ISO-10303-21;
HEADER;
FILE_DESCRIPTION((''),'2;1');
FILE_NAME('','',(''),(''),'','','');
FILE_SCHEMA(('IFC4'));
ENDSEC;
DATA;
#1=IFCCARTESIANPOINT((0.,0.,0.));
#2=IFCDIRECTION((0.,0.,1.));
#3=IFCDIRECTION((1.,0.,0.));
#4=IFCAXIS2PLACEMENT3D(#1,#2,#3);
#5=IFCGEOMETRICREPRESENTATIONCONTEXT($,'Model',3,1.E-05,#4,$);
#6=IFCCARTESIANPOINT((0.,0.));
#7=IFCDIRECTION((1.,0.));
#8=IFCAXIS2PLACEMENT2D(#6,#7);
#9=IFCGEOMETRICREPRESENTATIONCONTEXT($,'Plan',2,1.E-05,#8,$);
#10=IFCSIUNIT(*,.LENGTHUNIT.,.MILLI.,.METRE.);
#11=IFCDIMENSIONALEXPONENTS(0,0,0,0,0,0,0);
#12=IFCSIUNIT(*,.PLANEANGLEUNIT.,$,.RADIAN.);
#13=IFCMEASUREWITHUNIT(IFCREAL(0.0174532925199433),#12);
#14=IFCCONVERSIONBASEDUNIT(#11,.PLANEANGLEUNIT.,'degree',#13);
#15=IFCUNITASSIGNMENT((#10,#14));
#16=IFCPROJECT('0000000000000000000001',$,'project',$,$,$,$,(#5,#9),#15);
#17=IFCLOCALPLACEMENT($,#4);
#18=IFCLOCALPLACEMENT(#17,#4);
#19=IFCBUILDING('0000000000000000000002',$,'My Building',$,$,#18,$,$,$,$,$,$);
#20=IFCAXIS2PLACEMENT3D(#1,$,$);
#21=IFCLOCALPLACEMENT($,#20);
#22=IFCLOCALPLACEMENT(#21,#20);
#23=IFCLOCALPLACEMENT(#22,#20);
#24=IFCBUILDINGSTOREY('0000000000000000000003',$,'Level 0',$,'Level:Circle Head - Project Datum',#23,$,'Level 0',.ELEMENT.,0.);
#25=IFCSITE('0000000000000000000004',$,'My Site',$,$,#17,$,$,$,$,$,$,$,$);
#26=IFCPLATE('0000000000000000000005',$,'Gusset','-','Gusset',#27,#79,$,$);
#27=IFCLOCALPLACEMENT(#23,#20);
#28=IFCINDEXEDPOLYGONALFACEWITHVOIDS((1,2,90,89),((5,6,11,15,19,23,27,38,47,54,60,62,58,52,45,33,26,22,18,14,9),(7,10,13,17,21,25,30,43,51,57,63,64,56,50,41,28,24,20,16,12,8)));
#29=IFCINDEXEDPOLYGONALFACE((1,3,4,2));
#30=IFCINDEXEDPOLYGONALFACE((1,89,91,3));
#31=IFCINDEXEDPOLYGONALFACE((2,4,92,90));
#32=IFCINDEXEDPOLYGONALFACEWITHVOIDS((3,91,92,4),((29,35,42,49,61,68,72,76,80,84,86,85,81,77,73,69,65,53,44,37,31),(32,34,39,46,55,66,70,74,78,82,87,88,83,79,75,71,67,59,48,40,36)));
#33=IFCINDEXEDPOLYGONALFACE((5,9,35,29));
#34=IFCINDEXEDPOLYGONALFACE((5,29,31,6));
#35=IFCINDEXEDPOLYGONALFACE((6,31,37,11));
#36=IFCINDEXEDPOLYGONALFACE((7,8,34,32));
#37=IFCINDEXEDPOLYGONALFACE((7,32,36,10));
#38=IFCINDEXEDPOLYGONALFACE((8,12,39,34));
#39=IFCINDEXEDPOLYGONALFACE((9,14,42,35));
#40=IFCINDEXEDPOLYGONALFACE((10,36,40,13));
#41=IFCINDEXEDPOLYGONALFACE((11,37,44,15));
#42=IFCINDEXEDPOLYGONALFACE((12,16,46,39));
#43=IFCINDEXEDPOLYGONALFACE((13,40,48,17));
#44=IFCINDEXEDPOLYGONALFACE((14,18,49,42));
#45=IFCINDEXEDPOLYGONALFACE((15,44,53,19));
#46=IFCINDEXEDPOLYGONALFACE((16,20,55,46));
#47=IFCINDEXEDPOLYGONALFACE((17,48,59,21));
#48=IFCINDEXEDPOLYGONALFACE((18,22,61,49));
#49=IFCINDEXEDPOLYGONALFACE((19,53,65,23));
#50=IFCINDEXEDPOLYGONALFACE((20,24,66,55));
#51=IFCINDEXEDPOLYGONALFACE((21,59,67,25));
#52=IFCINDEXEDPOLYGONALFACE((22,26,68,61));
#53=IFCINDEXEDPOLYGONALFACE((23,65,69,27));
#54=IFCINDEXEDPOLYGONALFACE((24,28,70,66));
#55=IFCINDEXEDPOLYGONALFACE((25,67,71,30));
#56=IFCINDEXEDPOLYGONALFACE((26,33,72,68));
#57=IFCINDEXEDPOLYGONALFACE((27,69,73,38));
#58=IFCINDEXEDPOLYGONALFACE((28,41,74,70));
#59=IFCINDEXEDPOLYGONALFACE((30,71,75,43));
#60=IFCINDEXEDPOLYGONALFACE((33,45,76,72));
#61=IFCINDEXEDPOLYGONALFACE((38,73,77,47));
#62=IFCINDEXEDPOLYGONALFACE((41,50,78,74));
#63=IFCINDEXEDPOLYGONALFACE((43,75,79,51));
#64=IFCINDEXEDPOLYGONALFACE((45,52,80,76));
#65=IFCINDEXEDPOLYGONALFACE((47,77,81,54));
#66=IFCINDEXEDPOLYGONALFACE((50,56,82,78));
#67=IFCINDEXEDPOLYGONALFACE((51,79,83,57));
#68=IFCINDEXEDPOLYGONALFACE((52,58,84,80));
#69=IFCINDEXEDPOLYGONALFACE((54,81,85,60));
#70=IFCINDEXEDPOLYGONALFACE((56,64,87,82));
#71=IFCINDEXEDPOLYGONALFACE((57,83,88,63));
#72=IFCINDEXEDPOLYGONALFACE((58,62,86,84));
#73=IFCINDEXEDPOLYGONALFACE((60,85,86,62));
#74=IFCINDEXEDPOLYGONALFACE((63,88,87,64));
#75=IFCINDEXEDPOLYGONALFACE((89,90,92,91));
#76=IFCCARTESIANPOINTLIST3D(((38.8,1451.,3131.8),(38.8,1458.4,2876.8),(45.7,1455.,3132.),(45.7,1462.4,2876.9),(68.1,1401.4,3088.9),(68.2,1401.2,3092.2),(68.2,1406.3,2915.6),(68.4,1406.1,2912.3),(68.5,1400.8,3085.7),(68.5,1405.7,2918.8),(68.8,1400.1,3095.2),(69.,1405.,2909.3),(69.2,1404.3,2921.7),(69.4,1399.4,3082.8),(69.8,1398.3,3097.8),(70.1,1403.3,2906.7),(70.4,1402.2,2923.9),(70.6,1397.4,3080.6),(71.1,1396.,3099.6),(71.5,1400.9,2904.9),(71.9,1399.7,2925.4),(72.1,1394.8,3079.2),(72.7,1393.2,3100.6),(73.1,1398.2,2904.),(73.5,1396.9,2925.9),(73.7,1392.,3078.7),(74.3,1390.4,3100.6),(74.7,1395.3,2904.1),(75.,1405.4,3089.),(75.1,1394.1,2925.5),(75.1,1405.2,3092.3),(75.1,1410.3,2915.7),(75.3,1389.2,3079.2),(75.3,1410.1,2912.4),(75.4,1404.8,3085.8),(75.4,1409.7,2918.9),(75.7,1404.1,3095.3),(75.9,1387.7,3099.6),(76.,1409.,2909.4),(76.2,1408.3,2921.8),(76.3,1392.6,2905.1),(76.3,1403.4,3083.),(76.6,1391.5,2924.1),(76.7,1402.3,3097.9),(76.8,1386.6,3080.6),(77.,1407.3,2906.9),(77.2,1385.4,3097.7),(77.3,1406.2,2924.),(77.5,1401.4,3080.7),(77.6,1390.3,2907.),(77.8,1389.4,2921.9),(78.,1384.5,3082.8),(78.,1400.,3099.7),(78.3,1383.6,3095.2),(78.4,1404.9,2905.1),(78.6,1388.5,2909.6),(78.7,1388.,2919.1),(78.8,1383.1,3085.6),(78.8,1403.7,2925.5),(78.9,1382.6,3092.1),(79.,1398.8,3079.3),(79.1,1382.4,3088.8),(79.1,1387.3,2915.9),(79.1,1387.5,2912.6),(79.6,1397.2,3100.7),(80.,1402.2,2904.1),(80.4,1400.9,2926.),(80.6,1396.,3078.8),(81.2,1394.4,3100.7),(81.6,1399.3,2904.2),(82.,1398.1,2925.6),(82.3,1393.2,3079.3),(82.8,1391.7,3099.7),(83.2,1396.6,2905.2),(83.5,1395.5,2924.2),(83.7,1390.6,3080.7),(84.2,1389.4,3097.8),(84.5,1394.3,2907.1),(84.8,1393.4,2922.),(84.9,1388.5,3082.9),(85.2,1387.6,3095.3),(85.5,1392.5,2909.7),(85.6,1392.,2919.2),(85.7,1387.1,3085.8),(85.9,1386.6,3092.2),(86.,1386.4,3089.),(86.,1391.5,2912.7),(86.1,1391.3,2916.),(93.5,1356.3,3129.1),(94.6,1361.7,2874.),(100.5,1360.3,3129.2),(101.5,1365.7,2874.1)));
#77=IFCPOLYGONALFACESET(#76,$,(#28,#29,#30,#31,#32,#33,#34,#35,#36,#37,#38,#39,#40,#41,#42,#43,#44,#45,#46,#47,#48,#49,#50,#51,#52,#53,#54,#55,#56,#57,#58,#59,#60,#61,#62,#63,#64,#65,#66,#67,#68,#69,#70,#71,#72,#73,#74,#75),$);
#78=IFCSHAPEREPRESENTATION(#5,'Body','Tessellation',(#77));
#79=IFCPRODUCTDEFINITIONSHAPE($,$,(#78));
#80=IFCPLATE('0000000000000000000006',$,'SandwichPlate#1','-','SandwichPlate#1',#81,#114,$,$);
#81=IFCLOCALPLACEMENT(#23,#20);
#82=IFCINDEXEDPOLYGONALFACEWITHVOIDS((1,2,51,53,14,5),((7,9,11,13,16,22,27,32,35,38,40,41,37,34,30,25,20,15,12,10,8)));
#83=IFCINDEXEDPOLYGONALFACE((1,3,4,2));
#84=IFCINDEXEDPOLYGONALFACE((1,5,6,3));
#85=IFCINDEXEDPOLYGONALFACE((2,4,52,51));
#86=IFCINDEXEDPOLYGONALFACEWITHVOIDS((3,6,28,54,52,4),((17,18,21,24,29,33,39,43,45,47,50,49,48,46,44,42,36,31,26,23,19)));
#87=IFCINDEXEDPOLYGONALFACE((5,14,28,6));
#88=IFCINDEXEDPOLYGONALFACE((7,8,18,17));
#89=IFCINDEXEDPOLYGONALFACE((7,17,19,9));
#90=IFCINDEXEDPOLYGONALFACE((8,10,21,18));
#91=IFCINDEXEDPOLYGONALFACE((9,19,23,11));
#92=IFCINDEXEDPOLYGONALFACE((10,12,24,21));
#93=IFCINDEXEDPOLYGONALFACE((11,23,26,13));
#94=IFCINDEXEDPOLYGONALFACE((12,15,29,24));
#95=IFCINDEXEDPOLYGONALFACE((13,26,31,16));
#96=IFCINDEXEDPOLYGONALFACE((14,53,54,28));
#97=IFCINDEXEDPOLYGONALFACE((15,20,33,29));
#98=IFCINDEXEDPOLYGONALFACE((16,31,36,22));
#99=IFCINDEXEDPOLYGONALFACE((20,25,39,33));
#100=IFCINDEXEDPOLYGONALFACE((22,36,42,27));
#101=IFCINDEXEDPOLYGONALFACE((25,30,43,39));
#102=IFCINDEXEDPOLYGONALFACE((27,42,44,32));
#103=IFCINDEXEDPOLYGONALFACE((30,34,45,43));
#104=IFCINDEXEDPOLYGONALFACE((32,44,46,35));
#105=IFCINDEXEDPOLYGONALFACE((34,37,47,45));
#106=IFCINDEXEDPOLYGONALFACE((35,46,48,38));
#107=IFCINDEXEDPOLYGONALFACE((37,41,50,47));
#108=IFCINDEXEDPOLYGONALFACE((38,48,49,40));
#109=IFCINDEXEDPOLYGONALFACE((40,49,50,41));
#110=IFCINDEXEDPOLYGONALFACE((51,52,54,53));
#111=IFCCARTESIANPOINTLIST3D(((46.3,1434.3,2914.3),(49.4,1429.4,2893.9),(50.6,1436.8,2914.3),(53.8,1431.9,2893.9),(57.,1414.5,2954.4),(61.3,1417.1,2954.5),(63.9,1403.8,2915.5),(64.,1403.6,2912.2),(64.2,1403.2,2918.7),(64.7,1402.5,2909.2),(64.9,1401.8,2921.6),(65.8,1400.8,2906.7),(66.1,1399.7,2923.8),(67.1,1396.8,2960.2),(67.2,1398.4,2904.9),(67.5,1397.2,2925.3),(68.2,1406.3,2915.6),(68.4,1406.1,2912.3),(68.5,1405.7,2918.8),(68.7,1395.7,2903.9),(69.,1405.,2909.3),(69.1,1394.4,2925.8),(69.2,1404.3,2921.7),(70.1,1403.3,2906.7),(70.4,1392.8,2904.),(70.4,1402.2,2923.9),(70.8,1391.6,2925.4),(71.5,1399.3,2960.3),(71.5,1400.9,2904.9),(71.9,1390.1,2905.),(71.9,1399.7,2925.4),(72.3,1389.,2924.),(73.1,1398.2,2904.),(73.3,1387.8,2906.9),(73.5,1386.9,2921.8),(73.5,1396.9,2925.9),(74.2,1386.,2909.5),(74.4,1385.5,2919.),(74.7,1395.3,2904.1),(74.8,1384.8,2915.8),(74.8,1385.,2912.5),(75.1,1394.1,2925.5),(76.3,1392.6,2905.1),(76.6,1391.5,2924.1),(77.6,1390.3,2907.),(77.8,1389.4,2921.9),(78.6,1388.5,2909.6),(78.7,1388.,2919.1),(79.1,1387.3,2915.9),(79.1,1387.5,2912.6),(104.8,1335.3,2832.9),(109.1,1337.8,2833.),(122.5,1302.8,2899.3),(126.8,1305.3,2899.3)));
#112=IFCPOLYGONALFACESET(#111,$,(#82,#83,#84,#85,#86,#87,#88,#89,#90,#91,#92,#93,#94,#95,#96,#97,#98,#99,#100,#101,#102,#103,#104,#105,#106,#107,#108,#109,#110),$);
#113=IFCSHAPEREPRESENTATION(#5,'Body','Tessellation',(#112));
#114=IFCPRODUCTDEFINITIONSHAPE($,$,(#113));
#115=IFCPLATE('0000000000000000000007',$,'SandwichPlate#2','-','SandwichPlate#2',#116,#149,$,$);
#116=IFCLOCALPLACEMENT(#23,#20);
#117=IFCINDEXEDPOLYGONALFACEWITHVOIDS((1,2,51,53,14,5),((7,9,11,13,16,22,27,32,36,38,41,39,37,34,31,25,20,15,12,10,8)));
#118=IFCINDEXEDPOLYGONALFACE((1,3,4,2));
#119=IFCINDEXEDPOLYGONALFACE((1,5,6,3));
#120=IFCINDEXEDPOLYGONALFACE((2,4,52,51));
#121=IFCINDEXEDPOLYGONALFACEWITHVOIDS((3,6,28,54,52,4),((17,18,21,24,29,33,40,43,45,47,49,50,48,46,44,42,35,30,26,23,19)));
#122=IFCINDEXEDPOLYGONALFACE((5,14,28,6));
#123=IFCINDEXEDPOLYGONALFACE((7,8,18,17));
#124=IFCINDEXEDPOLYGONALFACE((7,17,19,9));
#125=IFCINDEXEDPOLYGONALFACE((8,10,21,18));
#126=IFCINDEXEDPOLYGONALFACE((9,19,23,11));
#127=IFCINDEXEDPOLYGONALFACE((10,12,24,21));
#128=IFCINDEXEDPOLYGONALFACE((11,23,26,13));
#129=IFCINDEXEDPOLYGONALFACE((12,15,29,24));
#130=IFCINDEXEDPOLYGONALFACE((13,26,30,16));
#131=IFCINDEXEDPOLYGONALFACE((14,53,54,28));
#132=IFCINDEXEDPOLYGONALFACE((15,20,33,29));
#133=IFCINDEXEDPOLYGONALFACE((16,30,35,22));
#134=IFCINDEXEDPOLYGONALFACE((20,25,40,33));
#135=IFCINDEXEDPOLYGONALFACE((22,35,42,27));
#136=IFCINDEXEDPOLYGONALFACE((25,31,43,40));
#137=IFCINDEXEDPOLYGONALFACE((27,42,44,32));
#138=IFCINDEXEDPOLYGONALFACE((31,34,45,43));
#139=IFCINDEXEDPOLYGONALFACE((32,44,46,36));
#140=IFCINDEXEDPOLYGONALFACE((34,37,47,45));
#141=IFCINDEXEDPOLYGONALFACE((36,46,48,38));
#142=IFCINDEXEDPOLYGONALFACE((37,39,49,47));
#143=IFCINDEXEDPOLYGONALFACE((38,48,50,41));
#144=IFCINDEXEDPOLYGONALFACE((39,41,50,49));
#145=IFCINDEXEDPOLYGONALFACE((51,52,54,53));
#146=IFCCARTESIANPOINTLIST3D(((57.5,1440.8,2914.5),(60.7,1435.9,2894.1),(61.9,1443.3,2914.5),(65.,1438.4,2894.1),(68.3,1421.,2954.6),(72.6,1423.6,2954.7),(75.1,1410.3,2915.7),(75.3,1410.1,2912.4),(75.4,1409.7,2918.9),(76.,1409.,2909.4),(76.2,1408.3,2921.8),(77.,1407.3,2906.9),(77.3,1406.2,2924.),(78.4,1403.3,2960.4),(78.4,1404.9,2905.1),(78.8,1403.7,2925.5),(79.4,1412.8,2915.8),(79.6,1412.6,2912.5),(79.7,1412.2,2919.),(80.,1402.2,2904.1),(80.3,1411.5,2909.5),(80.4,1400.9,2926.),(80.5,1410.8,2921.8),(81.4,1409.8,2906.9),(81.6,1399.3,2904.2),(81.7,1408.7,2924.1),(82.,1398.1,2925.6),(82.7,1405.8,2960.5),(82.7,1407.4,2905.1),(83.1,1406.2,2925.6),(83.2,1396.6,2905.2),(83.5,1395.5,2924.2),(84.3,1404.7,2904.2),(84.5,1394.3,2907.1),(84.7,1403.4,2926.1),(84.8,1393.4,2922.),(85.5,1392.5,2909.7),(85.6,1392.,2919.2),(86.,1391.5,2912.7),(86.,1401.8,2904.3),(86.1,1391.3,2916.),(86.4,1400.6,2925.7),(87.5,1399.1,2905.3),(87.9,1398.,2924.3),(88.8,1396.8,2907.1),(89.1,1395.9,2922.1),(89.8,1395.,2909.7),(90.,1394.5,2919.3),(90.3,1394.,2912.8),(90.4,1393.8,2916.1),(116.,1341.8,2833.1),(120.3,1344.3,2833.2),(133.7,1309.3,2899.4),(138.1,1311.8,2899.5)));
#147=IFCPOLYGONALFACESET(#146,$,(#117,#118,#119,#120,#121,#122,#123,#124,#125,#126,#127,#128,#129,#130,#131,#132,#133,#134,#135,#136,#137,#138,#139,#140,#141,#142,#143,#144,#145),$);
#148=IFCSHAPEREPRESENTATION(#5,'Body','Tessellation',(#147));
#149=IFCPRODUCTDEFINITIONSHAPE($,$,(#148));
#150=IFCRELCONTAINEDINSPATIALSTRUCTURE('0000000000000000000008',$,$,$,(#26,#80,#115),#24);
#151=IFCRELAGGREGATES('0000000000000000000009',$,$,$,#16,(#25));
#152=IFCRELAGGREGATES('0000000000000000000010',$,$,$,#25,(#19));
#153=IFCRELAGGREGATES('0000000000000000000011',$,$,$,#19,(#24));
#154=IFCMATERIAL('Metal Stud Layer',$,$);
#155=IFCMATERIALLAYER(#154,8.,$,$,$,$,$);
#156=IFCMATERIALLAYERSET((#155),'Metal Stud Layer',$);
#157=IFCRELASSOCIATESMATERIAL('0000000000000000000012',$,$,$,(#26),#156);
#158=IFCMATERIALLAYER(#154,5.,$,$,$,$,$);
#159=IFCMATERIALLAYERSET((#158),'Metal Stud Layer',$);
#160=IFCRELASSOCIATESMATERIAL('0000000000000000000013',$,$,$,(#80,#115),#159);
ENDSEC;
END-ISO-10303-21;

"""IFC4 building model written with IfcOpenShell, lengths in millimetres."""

from ifc_helpers import new_model, entity, si_unit, converted_unit, frame, origin, origin_with_axes, origin_2d_with_axis, place, context, project, spatial, polyline, circle, outline, extrude, material, layer, layer_set, element, save


model = new_model("IFC4")

# Units and contexts
model_context = context("Model", 3, precision=1e-05, world=origin_with_axes())
plan_context = context("Plan", 2, precision=1e-05, world=origin_2d_with_axis())
ifc_project = project(units=[si_unit("LENGTHUNIT", "METRE", prefix="MILLI"), converted_unit("PLANEANGLEUNIT", "degree", entity("IfcReal", 0.0174532925199433), si_unit("PLANEANGLEUNIT", "RADIAN"), dimensions=[0, 0, 0, 0, 0, 0, 0])], contexts=[model_context, plan_context])

# Site, building, storey
site_placement = place(None, origin_with_axes())
site = spatial("IfcSite", under=ifc_project, at=site_placement, Name="My Site")
building_placement = place(site_placement, origin_with_axes())
building = spatial("IfcBuilding", under=site, at=building_placement, Name="My Building")
placement_1 = place(None, origin())
placement_2 = place(placement_1, origin())
storey_placement = place(placement_2, origin())
storey = spatial("IfcBuildingStorey", under=building, at=storey_placement, Name="Level 0", ObjectType="Level:Circle Head - Project Datum", LongName="Level 0", CompositionType="ELEMENT", Elevation=0.0)

# Plates, openings
ifc_material_1 = material(Name="Metal Stud Layer")
ifc_layer_1 = layer(ifc_material_1, 8.0)
ifc_layer_set_1 = layer_set([ifc_layer_1], Name="Metal Stud Layer")
plate_1_placement = place(storey_placement, frame((46.7, 1453.3, 3131.9), z_axis=(-0.865935, -0.499948, -0.014432), x_axis=(0.0, 0.028855, -0.999584)))
plate_1 = element("IfcPlate", 1, at=plate_1_placement, inside=storey, material=ifc_layer_set_1, Name="Gusset", Description="-", ObjectType="Gusset", context=model_context, shape_type="SweptSolid", body=[
    extrude(outline(polyline([(0.0, -2.0), (255.1, -2.0), (255.1, 109.6), (0.0, 107.5), (0.0, -2.0)])), origin_with_axes(), (0.0, 0.0, 1.0), 8.0),
])
opening_1_placement = place(plate_1_placement, frame((40.4, 67.6, 8.5), z_axis=(0.0, 0.0, -1.0), x_axis=(-0.519479, 0.854483, 0.0)))
element("IfcOpeningElement", 2, at=opening_1_placement, cuts=plate_1, ObjectType="Opening", context=model_context, shape_type="SweptSolid", body=[
    extrude(circle(Radius=11.0, at=origin_2d_with_axis()), origin(), (0.0, 0.0, 1.0), 9.0),
])
opening_2_placement = place(plate_1_placement, frame((215.3, 67.8, 8.5), z_axis=(0.0, 0.0, -1.0), x_axis=(0.465705, 0.88494, 0.0)))
element("IfcOpeningElement", 3, at=opening_2_placement, cuts=plate_1, ObjectType="Opening", context=model_context, shape_type="SweptSolid", body=[
    extrude(circle(Radius=11.0, at=origin_2d_with_axis()), origin(), (0.0, 0.0, 1.0), 9.0),
])
ifc_layer_2 = layer(ifc_material_1, 5.0)
ifc_layer_set_2 = layer_set([ifc_layer_2], Name="Metal Stud Layer")
plate_2_placement = place(storey_placement, frame((42.8, 1440.7, 2901.2), z_axis=(0.865935, 0.499948, 0.014432), x_axis=(0.232925, -0.428638, 0.872935)))
plate_2 = element("IfcPlate", 4, at=plate_2_placement, inside=storey, material=ifc_layer_set_2, Name="SandwichPlate#1", Description="-", ObjectType="SandwichPlate#1", context=model_context, shape_type="SweptSolid", body=[
    extrude(outline(polyline([(0.0, 0.0), (76.0, 0.0), (76.0, 140.0), (0.0, 140.0), (0.0, 0.0)])), origin_with_axes(), (0.0, 0.0, 1.0), 5.0),
])
opening_3_placement = place(plate_2_placement, frame((0.0, 0.0, 0.0), z_axis=(0.0, 0.0, 1.0), x_axis=(1.0, 0.0, 0.0)))
element("IfcOpeningElement", 5, at=opening_3_placement, cuts=plate_2, ObjectType="Opening", context=model_context, shape_type="SweptSolid", body=[
    extrude(outline(polyline([(76.0, 0.0), (76.0, 15.0), (61.0, 0.0), (76.0, 0.0)])), origin(), (0.0, 0.0, 1.0), 5.0),
])
opening_4_placement = place(plate_2_placement, frame((38.0, 40.0, -0.5), z_axis=(0.0, 0.0, 1.0), x_axis=(0.0, 1.0, 0.0)))
element("IfcOpeningElement", 6, at=opening_4_placement, cuts=plate_2, ObjectType="Opening", context=model_context, shape_type="SweptSolid", body=[
    extrude(circle(Radius=11.0, at=origin_2d_with_axis()), origin(), (0.0, 0.0, 1.0), 6.0),
])
opening_5_placement = place(plate_2_placement, frame((0.0, 0.0, 0.0), z_axis=(0.0, 0.0, 1.0), x_axis=(1.0, 0.0, 0.0)))
element("IfcOpeningElement", 7, at=opening_5_placement, cuts=plate_2, ObjectType="Opening", context=model_context, shape_type="SweptSolid", body=[
    extrude(outline(polyline([(0.0, 0.0), (15.0, 0.0), (0.0, 15.0), (0.0, 0.0)])), origin(), (0.0, 0.0, 1.0), 5.0),
])
plate_3_placement = place(storey_placement, frame((54.1, 1447.2, 2901.4), z_axis=(0.865935, 0.499948, 0.014432), x_axis=(0.232925, -0.428638, 0.872935)))
plate_3 = element("IfcPlate", 8, at=plate_3_placement, inside=storey, material=ifc_layer_set_2, Name="SandwichPlate#2", Description="-", ObjectType="SandwichPlate#2", context=model_context, shape_type="SweptSolid", body=[
    extrude(outline(polyline([(0.0, 0.0), (76.0, 0.0), (76.0, 140.0), (0.0, 140.0), (0.0, 0.0)])), origin_with_axes(), (0.0, 0.0, 1.0), 5.0),
])
opening_6_placement = place(plate_3_placement, frame((0.0, 0.0, 0.0), z_axis=(0.0, 0.0, 1.0), x_axis=(1.0, 0.0, 0.0)))
element("IfcOpeningElement", 9, at=opening_6_placement, cuts=plate_3, ObjectType="Opening", context=model_context, shape_type="SweptSolid", body=[
    extrude(outline(polyline([(76.0, 0.0), (76.0, 15.0), (61.0, 0.0), (76.0, 0.0)])), origin(), (0.0, 0.0, 1.0), 5.0),
])
opening_7_placement = place(plate_3_placement, frame((38.0, 40.0, -0.5), z_axis=(0.0, 0.0, 1.0), x_axis=(0.0, 1.0, 0.0)))
element("IfcOpeningElement", 10, at=opening_7_placement, cuts=plate_3, ObjectType="Opening", context=model_context, shape_type="SweptSolid", body=[
    extrude(circle(Radius=11.0, at=origin_2d_with_axis()), origin(), (0.0, 0.0, 1.0), 6.0),
])
opening_8_placement = place(plate_3_placement, frame((0.0, 0.0, 0.0), z_axis=(0.0, 0.0, 1.0), x_axis=(1.0, 0.0, 0.0)))
element("IfcOpeningElement", 11, at=opening_8_placement, cuts=plate_3, ObjectType="Opening", context=model_context, shape_type="SweptSolid", body=[
    extrude(outline(polyline([(0.0, 0.0), (15.0, 0.0), (0.0, 15.0), (0.0, 0.0)])), origin(), (0.0, 0.0, 1.0), 5.0),
])

save(model, "model.ifc")
